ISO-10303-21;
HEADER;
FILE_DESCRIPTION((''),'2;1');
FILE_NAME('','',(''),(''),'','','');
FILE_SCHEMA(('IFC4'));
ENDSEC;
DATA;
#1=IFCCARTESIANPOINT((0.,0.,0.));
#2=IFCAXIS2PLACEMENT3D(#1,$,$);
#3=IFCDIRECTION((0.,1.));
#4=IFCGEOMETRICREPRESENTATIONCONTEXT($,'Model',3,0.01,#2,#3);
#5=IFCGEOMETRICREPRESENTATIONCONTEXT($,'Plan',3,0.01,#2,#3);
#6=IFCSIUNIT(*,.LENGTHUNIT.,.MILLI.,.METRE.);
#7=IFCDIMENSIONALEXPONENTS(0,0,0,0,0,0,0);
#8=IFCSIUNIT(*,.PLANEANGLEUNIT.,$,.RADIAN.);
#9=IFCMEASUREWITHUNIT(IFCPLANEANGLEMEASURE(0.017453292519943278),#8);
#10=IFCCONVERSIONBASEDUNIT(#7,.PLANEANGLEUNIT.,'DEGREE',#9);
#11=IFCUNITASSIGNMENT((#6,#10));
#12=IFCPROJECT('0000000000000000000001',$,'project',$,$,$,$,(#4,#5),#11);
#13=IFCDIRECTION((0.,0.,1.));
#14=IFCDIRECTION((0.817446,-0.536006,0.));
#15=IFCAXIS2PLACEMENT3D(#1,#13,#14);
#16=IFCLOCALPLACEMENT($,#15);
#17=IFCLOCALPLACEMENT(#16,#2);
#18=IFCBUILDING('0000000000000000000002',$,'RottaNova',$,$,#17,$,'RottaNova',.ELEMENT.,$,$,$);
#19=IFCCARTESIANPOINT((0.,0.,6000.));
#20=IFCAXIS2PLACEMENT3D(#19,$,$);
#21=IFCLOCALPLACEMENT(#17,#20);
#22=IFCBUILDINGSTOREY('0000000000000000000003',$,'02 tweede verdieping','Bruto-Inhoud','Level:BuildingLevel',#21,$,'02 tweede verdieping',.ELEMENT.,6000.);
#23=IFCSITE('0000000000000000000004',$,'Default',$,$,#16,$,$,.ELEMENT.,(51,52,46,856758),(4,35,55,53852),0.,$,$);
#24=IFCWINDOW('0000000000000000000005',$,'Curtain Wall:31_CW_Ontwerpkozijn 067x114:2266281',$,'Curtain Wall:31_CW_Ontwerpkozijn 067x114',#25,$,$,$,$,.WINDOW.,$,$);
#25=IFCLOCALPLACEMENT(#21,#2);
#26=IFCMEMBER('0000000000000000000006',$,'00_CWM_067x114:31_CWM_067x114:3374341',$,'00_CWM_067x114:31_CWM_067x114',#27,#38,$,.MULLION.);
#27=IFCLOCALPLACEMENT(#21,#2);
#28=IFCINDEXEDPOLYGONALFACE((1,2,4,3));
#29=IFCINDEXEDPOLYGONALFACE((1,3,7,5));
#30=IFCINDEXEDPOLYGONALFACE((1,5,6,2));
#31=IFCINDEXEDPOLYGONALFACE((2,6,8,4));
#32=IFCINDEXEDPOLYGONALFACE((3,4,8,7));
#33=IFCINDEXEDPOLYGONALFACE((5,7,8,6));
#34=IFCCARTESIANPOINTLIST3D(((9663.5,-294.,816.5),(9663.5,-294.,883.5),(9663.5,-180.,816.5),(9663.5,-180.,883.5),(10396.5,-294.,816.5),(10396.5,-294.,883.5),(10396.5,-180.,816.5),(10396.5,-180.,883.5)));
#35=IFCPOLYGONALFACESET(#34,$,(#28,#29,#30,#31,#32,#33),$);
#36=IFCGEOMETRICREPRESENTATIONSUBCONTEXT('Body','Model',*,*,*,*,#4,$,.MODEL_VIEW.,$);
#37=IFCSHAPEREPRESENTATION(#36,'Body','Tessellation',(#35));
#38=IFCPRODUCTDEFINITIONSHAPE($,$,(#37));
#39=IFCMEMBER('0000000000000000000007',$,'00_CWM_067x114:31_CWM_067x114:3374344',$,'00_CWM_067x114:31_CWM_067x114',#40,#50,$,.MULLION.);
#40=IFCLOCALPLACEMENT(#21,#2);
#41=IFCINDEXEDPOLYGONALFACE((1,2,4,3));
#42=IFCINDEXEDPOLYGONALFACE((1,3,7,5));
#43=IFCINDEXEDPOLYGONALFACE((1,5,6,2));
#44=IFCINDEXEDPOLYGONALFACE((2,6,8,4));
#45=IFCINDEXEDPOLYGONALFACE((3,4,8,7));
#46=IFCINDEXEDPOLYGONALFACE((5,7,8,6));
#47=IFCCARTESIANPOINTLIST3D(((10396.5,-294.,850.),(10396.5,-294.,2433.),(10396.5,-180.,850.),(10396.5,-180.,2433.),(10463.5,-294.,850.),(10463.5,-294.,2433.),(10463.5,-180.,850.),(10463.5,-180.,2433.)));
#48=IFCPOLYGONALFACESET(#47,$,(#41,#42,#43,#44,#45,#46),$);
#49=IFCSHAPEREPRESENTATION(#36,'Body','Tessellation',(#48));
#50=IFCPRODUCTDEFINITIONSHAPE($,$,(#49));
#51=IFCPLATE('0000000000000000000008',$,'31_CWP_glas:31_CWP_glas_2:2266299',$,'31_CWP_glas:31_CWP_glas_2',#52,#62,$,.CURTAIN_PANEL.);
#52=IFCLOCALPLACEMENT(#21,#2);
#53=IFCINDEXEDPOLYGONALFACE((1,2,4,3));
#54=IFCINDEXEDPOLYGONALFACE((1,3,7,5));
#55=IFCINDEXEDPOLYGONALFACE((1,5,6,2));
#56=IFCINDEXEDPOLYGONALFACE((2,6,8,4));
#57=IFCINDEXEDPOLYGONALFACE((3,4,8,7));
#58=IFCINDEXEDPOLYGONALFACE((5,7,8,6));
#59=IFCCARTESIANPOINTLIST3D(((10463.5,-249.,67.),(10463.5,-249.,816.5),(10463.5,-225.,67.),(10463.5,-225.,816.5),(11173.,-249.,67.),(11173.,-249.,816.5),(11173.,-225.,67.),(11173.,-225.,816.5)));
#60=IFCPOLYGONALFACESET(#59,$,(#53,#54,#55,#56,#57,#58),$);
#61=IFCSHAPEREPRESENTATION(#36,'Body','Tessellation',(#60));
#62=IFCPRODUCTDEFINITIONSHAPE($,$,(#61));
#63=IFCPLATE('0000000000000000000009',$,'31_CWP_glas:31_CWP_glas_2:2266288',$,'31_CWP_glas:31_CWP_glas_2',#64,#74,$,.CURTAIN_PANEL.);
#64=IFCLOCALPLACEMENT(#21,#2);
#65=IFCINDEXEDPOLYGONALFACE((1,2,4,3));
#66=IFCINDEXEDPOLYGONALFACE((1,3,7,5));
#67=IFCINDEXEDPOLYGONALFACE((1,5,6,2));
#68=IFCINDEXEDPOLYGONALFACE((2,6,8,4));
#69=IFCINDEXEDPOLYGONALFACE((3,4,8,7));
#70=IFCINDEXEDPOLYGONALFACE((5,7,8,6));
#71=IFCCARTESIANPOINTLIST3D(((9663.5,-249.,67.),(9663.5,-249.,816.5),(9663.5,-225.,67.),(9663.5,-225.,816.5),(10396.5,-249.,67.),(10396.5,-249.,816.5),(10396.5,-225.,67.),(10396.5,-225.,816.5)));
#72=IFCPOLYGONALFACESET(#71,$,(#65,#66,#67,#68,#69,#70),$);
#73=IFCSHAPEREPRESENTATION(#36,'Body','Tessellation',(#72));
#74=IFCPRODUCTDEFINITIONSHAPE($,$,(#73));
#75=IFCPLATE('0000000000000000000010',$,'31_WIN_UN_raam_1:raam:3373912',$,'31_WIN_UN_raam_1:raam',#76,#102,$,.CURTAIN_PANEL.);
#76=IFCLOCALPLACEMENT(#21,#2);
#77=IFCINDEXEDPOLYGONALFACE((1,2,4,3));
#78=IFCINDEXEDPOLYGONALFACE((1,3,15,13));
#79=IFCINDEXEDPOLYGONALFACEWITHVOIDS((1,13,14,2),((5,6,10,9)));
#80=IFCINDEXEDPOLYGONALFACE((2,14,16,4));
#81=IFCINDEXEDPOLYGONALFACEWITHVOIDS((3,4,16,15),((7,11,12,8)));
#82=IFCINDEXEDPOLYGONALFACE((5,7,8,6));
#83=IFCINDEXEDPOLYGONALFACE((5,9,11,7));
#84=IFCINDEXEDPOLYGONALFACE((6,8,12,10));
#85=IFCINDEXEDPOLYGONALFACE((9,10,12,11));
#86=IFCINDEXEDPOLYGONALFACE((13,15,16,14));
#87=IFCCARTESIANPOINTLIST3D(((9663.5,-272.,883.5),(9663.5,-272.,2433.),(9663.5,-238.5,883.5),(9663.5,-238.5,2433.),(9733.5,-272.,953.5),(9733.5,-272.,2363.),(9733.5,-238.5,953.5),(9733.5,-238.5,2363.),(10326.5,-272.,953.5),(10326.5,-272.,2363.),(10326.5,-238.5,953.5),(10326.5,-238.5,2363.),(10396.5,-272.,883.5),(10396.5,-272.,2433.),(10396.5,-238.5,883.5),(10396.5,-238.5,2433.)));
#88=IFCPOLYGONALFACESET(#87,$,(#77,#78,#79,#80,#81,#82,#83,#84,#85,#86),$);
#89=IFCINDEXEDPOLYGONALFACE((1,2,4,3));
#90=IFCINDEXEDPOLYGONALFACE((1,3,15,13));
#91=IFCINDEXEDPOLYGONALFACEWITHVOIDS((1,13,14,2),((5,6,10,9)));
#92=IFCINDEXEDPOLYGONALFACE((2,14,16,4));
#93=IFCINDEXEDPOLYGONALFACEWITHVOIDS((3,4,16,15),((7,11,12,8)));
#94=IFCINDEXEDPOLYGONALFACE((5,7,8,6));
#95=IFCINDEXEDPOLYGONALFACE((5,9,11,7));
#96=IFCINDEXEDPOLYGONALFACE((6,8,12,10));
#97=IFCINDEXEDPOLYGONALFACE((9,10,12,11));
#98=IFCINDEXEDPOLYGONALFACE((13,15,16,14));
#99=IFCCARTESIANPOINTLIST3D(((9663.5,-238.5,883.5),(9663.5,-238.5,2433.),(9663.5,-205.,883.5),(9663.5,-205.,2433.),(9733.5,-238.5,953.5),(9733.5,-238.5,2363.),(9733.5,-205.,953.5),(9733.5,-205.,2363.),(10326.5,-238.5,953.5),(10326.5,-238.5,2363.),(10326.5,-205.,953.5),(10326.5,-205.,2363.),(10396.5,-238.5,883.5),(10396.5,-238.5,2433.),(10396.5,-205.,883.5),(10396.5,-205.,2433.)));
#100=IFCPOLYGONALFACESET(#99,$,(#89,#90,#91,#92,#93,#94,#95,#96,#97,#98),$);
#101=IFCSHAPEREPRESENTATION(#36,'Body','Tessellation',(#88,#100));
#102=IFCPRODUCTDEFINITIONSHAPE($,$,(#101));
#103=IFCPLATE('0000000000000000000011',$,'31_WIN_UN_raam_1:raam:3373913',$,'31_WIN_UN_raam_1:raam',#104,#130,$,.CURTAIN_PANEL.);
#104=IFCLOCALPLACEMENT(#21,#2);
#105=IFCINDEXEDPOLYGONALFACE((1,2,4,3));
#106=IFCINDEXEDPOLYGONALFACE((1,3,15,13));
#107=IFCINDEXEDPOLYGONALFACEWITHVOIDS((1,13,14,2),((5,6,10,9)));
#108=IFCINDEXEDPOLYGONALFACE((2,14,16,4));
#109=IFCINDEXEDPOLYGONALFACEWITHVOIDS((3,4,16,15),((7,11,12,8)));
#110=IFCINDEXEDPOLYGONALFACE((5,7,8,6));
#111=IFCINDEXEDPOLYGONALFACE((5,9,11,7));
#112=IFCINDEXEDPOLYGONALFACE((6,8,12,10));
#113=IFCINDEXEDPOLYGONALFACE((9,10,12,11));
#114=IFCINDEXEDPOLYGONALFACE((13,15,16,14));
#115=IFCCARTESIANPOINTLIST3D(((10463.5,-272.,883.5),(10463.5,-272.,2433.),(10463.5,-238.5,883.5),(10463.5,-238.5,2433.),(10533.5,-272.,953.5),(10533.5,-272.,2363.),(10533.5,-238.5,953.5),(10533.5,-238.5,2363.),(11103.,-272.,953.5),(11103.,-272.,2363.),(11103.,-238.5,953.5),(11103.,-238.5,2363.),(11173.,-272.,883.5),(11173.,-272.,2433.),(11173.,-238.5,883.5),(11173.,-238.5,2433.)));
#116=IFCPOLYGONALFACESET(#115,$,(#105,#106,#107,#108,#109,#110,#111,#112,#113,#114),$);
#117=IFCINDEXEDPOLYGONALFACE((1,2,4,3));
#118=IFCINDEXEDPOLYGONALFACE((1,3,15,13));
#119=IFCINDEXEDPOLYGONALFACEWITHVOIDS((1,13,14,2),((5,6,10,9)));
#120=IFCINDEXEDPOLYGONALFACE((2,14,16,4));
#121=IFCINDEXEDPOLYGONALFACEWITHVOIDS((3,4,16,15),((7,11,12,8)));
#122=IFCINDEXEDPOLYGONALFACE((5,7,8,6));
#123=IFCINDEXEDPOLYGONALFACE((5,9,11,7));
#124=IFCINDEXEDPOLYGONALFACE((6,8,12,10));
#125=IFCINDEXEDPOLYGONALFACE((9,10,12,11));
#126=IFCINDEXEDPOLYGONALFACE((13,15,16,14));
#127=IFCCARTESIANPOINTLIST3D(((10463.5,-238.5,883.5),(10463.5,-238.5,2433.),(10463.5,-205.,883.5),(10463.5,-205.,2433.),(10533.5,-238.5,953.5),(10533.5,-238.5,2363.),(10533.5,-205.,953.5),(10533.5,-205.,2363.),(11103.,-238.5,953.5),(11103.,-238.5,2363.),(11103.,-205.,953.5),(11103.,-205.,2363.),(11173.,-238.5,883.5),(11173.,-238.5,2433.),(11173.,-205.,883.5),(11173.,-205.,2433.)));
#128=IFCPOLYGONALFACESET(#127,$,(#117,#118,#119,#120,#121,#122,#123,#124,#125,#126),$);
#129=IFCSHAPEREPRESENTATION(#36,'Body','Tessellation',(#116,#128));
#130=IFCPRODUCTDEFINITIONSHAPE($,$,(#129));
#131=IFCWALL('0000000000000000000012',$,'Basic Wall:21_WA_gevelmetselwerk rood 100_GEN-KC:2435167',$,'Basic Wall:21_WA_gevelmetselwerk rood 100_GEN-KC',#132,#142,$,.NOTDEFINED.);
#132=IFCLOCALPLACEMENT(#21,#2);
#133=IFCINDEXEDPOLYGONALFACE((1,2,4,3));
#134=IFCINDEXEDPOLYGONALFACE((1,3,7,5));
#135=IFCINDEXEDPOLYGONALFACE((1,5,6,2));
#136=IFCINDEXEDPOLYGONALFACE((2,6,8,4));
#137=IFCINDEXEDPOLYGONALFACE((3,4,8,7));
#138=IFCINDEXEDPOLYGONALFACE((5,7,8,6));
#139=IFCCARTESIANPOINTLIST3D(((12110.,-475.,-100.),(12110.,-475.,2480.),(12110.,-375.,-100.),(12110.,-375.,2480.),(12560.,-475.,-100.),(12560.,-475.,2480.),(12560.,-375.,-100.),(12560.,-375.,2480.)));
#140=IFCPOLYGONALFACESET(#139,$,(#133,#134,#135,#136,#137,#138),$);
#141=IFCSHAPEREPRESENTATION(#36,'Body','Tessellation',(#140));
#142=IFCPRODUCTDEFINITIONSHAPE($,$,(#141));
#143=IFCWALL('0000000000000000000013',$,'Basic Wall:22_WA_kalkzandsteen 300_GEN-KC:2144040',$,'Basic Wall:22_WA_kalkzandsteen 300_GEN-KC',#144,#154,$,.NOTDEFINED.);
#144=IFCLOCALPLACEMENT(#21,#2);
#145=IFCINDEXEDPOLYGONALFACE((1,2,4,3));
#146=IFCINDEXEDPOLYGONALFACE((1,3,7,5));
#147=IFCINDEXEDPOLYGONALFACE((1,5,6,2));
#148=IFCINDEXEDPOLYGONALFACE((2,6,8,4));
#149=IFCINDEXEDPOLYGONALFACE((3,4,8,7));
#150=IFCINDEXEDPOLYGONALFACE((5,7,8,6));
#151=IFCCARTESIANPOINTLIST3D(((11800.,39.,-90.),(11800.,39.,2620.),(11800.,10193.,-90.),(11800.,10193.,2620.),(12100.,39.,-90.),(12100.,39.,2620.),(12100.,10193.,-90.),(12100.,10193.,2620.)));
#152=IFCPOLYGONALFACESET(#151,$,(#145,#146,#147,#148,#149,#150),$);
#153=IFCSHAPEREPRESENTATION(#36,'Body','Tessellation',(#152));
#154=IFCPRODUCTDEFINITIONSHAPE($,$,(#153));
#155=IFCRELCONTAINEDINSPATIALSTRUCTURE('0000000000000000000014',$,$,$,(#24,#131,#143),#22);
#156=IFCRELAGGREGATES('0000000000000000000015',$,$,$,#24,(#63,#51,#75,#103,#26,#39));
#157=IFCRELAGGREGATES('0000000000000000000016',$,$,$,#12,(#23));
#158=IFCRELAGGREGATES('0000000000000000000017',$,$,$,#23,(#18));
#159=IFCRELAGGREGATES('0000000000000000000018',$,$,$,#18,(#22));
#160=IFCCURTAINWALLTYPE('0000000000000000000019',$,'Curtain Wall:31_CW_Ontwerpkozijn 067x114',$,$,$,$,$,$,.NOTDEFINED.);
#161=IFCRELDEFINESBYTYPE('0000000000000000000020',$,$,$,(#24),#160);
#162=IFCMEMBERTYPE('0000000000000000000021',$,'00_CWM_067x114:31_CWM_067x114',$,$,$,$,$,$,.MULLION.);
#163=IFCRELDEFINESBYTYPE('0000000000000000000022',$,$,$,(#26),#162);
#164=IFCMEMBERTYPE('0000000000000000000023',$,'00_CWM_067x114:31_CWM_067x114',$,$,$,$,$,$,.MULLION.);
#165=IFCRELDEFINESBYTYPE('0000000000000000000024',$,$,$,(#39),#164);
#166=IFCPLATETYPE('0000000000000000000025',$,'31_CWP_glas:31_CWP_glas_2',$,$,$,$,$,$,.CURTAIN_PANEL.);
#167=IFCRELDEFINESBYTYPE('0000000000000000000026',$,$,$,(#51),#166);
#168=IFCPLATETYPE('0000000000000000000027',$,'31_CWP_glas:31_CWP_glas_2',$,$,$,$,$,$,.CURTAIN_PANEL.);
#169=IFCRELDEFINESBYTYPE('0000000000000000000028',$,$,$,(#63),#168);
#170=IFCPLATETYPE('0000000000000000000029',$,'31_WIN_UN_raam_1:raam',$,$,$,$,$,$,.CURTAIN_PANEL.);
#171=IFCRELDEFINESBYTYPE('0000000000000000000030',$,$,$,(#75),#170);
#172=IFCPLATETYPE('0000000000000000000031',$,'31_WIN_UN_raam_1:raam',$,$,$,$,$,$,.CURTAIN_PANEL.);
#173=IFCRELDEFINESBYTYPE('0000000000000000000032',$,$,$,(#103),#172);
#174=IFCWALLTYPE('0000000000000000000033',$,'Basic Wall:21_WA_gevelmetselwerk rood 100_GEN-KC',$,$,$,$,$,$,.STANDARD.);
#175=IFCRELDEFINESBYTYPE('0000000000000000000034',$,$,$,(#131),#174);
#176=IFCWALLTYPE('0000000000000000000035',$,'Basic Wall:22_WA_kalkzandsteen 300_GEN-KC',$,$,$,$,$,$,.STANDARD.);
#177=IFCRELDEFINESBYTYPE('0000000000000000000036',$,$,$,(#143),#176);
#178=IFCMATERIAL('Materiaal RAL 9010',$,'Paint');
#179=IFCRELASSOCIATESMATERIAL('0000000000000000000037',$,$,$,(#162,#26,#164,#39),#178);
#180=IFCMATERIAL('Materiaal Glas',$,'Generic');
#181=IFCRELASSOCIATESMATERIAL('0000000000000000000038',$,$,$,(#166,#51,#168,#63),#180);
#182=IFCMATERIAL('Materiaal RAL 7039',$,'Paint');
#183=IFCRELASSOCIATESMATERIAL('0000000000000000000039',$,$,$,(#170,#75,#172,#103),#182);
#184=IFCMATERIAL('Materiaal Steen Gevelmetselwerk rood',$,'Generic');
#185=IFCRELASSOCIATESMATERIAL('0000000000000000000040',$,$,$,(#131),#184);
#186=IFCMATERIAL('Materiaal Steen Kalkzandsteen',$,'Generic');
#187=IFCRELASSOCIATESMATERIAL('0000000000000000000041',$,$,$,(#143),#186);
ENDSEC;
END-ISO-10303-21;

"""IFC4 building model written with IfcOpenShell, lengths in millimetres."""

from ifc_helpers import new_model, entity, si_unit, converted_unit, direction, frame, origin, place, context, subcontext, project, spatial, indexed_curve, outline, extrude, source, transform, mapped, material, type_object, type_shapes, element, aggregate, save


model = new_model("IFC4")

# Units and contexts
model_context = context("Model", 3, precision=0.01, world=origin(), true_north=direction((0.0, 1.0)))
plan_context = context("Plan", 3, precision=0.01, world=origin(), true_north=direction((0.0, 1.0)))
body_context = subcontext(model_context, "Body", "Model", "MODEL_VIEW")
ifc_project = project(units=[si_unit("LENGTHUNIT", "METRE", prefix="MILLI"), converted_unit("PLANEANGLEUNIT", "DEGREE", entity("IfcPlaneAngleMeasure", 0.017453292519943278), si_unit("PLANEANGLEUNIT", "RADIAN"), dimensions=[0, 0, 0, 0, 0, 0, 0])], contexts=[model_context, plan_context])

# Site, building, storey
site_placement = place(None, frame((0.0, 0.0, 0.0), z_axis=(0.0, 0.0, 1.0), x_axis=(0.817446, -0.536006, 0.0)))
site = spatial("IfcSite", under=ifc_project, at=site_placement, Name="Default", CompositionType="ELEMENT", RefLatitude=(51, 52, 46, 856758), RefLongitude=(4, 35, 55, 53852), RefElevation=0.0)
building_placement = place(site_placement, origin())
building = spatial("IfcBuilding", under=site, at=building_placement, Name="RottaNova", LongName="RottaNova", CompositionType="ELEMENT")
storey_placement = place(building_placement, frame((0.0, 0.0, 6000.0)))
storey = spatial("IfcBuildingStorey", under=building, at=storey_placement, Name="02 tweede verdieping", Description="Bruto-Inhoud", ObjectType="Level:BuildingLevel", LongName="02 tweede verdieping", CompositionType="ELEMENT", Elevation=6000.0)

# Shared definitions
curtain_wall_type = type_object("IfcCurtainWallType", Name="Curtain Wall:31_CW_Ontwerpkozijn 067x114", PredefinedType="NOTDEFINED")
ifc_material_1 = material(Name="Materiaal RAL 7039", Category="Paint")

# Window, members, plates
window_1_placement = place(storey_placement, frame((0.0, 0.0, -6000.0)))
window_1 = element("IfcWindow", 1, at=window_1_placement, inside=storey, type_object=curtain_wall_type, Name="Curtain Wall:31_CW_Ontwerpkozijn 067x114:2266281", ObjectType="Curtain Wall:31_CW_Ontwerpkozijn 067x114", PredefinedType="WINDOW")
ifc_material_2 = material(Name="Materiaal RAL 9010", Category="Paint")
member_type_1 = type_object("IfcMemberType", Name="00_CWM_067x114:31_CWM_067x114", PredefinedType="MULLION", material=ifc_material_2)
shared_shape_1 = source(origin(), body_context, "Body", "SweptSolid", [
    extrude(outline(indexed_curve([(-33.5, -57.0), (33.5, -57.0), (33.5, 57.0), (-33.5, 57.0), (-33.5, -57.0)], self_intersect=False)), frame((0.0, 57.0, -733.0), z_axis=(0.0, 0.0, 1.0), x_axis=(-1.0, 0.0, 0.0)), (0.0, 0.0, 1.0), 733.0),
])
type_shapes(member_type_1, [shared_shape_1])
member_1_placement = place(window_1_placement, frame((10396.5, -180.0, 6850.0), z_axis=(1.0, 0.0, 0.0), x_axis=(0.0, 0.0, 1.0)))
member_1 = element("IfcMember", 2, at=member_1_placement, type_object=member_type_1, material=ifc_material_2, Name="00_CWM_067x114:31_CWM_067x114:3374341", ObjectType="00_CWM_067x114:31_CWM_067x114", PredefinedType="MULLION", context=body_context, shape_type="MappedRepresentation", body=[
    mapped(shared_shape_1, transform((0.0, 0.0, 0.0), scale=1.0)),
])
member_type_2 = type_object("IfcMemberType", Name="00_CWM_067x114:31_CWM_067x114", PredefinedType="MULLION", material=ifc_material_2)
shared_shape_2 = source(origin(), body_context, "Body", "SweptSolid", [
    extrude(outline(indexed_curve([(-33.5, -57.0), (33.5, -57.0), (33.5, 57.0), (-33.5, 57.0), (-33.5, -57.0)], self_intersect=False)), frame((0.0, 57.0, -1583.0), z_axis=(0.0, 0.0, 1.0), x_axis=(-1.0, 0.0, 0.0)), (0.0, 0.0, 1.0), 1583.0),
])
type_shapes(member_type_2, [shared_shape_2])
member_2_placement = place(window_1_placement, frame((10430.0, -180.0, 6850.0), z_axis=(0.0, 0.0, -1.0), x_axis=(1.0, 0.0, 0.0)))
member_2 = element("IfcMember", 3, at=member_2_placement, type_object=member_type_2, material=ifc_material_2, Name="00_CWM_067x114:31_CWM_067x114:3374344", ObjectType="00_CWM_067x114:31_CWM_067x114", PredefinedType="MULLION", context=body_context, shape_type="MappedRepresentation", body=[
    mapped(shared_shape_2, transform((0.0, 0.0, 0.0), scale=1.0)),
])
ifc_material_3 = material(Name="Materiaal Glas", Category="Generic")
plate_type_1 = type_object("IfcPlateType", Name="31_CWP_glas:31_CWP_glas_2", PredefinedType="CURTAIN_PANEL", material=ifc_material_3)
shared_shape_3 = source(origin(), body_context, "Body", "SweptSolid", [
    extrude(outline(indexed_curve([(-12.0, -354.8), (12.0, -354.8), (12.0, 354.8), (-12.0, 354.8), (-12.0, -354.8)], self_intersect=False)), frame((0.0, -57.0, 0.0), z_axis=(0.0, 0.0, 1.0), x_axis=(0.0, 1.0, 0.0)), (0.0, 0.0, 1.0), 749.5),
])
type_shapes(plate_type_1, [shared_shape_3])
plate_1_placement = place(window_1_placement, frame((10818.2, -180.0, 6067.0)))
plate_1 = element("IfcPlate", 4, at=plate_1_placement, type_object=plate_type_1, material=ifc_material_3, Name="31_CWP_glas:31_CWP_glas_2:2266299", ObjectType="31_CWP_glas:31_CWP_glas_2", PredefinedType="CURTAIN_PANEL", context=body_context, shape_type="MappedRepresentation", body=[
    mapped(shared_shape_3, transform((0.0, 0.0, 0.0), scale=1.0)),
])
plate_type_2 = type_object("IfcPlateType", Name="31_CWP_glas:31_CWP_glas_2", PredefinedType="CURTAIN_PANEL", material=ifc_material_3)
shared_shape_4 = source(origin(), body_context, "Body", "SweptSolid", [
    extrude(outline(indexed_curve([(-12.0, -366.5), (12.0, -366.5), (12.0, 366.5), (-12.0, 366.5), (-12.0, -366.5)], self_intersect=False)), frame((0.0, -57.0, 0.0), z_axis=(0.0, 0.0, 1.0), x_axis=(0.0, 1.0, 0.0)), (0.0, 0.0, 1.0), 749.5),
])
type_shapes(plate_type_2, [shared_shape_4])
plate_2_placement = place(window_1_placement, frame((10030.0, -180.0, 6067.0)))
plate_2 = element("IfcPlate", 5, at=plate_2_placement, type_object=plate_type_2, material=ifc_material_3, Name="31_CWP_glas:31_CWP_glas_2:2266288", ObjectType="31_CWP_glas:31_CWP_glas_2", PredefinedType="CURTAIN_PANEL", context=body_context, shape_type="MappedRepresentation", body=[
    mapped(shared_shape_4, transform((0.0, 0.0, 0.0), scale=1.0)),
])
plate_type_3 = type_object("IfcPlateType", Name="31_WIN_UN_raam_1:raam", PredefinedType="CURTAIN_PANEL", material=ifc_material_1)
shared_shape_5 = source(origin(), body_context, "Body", "SweptSolid", [
    extrude(outline(indexed_curve([(-366.5, -774.7), (366.5, -774.7), (366.5, 774.7), (-366.5, 774.7), (-366.5, -774.7)], self_intersect=False), holes=[indexed_curve([(-296.5, 704.7), (296.5, 704.7), (296.5, -704.8), (-296.5, -704.8), (-296.5, 704.7)], self_intersect=False)]), frame((0.0, -92.0, 774.8), z_axis=(0.0, 1.0, 0.0), x_axis=(1.0, 0.0, 0.0)), (0.0, 0.0, 1.0), 33.5),
    extrude(outline(indexed_curve([(-366.5, -774.7), (366.5, -774.7), (366.5, 774.7), (-366.5, 774.7), (-366.5, -774.7)], self_intersect=False), holes=[indexed_curve([(-296.5, 704.7), (296.5, 704.7), (296.5, -704.8), (-296.5, -704.8), (-296.5, 704.7)], self_intersect=False)]), frame((0.0, -58.5, 774.8), z_axis=(0.0, 1.0, 0.0), x_axis=(1.0, 0.0, 0.0)), (0.0, 0.0, 1.0), 33.5),
])
type_shapes(plate_type_3, [shared_shape_5])
plate_3_placement = place(window_1_placement, frame((10030.0, -180.0, 6883.5)))
plate_3 = element("IfcPlate", 6, at=plate_3_placement, type_object=plate_type_3, material=ifc_material_1, Name="31_WIN_UN_raam_1:raam:3373912", ObjectType="31_WIN_UN_raam_1:raam", PredefinedType="CURTAIN_PANEL", context=body_context, shape_type="MappedRepresentation", body=[
    mapped(shared_shape_5, transform((0.0, 0.0, 0.0), scale=1.0)),
])
plate_type_4 = type_object("IfcPlateType", Name="31_WIN_UN_raam_1:raam", PredefinedType="CURTAIN_PANEL", material=ifc_material_1)
shared_shape_6 = source(origin(), body_context, "Body", "SweptSolid", [
    extrude(outline(indexed_curve([(-354.7, -774.7), (354.7, -774.7), (354.7, 774.7), (-354.7, 774.7), (-354.7, -774.7)], self_intersect=False), holes=[indexed_curve([(-284.7, 704.7), (284.7, 704.7), (284.7, -704.8), (-284.7, -704.8), (-284.7, 704.7)], self_intersect=False)]), frame((0.0, -92.0, 774.8), z_axis=(0.0, 1.0, 0.0), x_axis=(1.0, 0.0, 0.0)), (0.0, 0.0, 1.0), 33.5),
    extrude(outline(indexed_curve([(-354.7, -774.7), (354.7, -774.7), (354.7, 774.7), (-354.7, 774.7), (-354.7, -774.7)], self_intersect=False), holes=[indexed_curve([(-284.7, 704.7), (284.7, 704.7), (284.7, -704.8), (-284.7, -704.8), (-284.7, 704.7)], self_intersect=False)]), frame((0.0, -58.5, 774.8), z_axis=(0.0, 1.0, 0.0), x_axis=(1.0, 0.0, 0.0)), (0.0, 0.0, 1.0), 33.5),
])
type_shapes(plate_type_4, [shared_shape_6])
plate_4_placement = place(window_1_placement, frame((10818.2, -180.0, 6883.5)))
plate_4 = element("IfcPlate", 7, at=plate_4_placement, type_object=plate_type_4, material=ifc_material_1, Name="31_WIN_UN_raam_1:raam:3373913", ObjectType="31_WIN_UN_raam_1:raam", PredefinedType="CURTAIN_PANEL", context=body_context, shape_type="MappedRepresentation", body=[
    mapped(shared_shape_6, transform((0.0, 0.0, 0.0), scale=1.0)),
])
aggregate(window_1, [plate_2, plate_1, plate_3, plate_4, member_1, member_2])

# Walls
ifc_material_4 = material(Name="Materiaal Steen Gevelmetselwerk rood", Category="Generic")
wall_type_1 = type_object("IfcWallType", Name="Basic Wall:21_WA_gevelmetselwerk rood 100_GEN-KC", PredefinedType="STANDARD")
wall_1_placement = place(storey_placement, frame((12560.0, -425.0, -100.0), z_axis=(0.0, 0.0, 1.0), x_axis=(-1.0, 0.0, 0.0)))
element("IfcWall", 8, at=wall_1_placement, inside=storey, type_object=wall_type_1, material=ifc_material_4, Name="Basic Wall:21_WA_gevelmetselwerk rood 100_GEN-KC:2435167", ObjectType="Basic Wall:21_WA_gevelmetselwerk rood 100_GEN-KC", PredefinedType="NOTDEFINED", context=body_context, shape_type="SweptSolid", body=[
    extrude(outline(indexed_curve([(450.0, 50.0), (0.0, 50.0), (0.0, -50.0), (450.0, -50.0), (450.0, 50.0)], self_intersect=False)), origin(), (0.0, 0.0, 1.0), 2580.0),
])
ifc_material_5 = material(Name="Materiaal Steen Kalkzandsteen", Category="Generic")
wall_type_2 = type_object("IfcWallType", Name="Basic Wall:22_WA_kalkzandsteen 300_GEN-KC", PredefinedType="STANDARD")
wall_2_placement = place(storey_placement, frame((11950.0, 39.0, -90.0), z_axis=(0.0, 0.0, 1.0), x_axis=(0.0, 1.0, 0.0)))
element("IfcWall", 9, at=wall_2_placement, inside=storey, type_object=wall_type_2, material=ifc_material_5, Name="Basic Wall:22_WA_kalkzandsteen 300_GEN-KC:2144040", ObjectType="Basic Wall:22_WA_kalkzandsteen 300_GEN-KC", PredefinedType="NOTDEFINED", context=body_context, shape_type="SweptSolid", body=[
    extrude(outline(indexed_curve([(10154.0, 150.0), (0.0, 150.0), (0.0, -150.0), (10154.0, -150.0), (10154.0, 150.0)], self_intersect=False)), origin(), (0.0, 0.0, 1.0), 2710.0),
])

save(model, "model.ifc")
